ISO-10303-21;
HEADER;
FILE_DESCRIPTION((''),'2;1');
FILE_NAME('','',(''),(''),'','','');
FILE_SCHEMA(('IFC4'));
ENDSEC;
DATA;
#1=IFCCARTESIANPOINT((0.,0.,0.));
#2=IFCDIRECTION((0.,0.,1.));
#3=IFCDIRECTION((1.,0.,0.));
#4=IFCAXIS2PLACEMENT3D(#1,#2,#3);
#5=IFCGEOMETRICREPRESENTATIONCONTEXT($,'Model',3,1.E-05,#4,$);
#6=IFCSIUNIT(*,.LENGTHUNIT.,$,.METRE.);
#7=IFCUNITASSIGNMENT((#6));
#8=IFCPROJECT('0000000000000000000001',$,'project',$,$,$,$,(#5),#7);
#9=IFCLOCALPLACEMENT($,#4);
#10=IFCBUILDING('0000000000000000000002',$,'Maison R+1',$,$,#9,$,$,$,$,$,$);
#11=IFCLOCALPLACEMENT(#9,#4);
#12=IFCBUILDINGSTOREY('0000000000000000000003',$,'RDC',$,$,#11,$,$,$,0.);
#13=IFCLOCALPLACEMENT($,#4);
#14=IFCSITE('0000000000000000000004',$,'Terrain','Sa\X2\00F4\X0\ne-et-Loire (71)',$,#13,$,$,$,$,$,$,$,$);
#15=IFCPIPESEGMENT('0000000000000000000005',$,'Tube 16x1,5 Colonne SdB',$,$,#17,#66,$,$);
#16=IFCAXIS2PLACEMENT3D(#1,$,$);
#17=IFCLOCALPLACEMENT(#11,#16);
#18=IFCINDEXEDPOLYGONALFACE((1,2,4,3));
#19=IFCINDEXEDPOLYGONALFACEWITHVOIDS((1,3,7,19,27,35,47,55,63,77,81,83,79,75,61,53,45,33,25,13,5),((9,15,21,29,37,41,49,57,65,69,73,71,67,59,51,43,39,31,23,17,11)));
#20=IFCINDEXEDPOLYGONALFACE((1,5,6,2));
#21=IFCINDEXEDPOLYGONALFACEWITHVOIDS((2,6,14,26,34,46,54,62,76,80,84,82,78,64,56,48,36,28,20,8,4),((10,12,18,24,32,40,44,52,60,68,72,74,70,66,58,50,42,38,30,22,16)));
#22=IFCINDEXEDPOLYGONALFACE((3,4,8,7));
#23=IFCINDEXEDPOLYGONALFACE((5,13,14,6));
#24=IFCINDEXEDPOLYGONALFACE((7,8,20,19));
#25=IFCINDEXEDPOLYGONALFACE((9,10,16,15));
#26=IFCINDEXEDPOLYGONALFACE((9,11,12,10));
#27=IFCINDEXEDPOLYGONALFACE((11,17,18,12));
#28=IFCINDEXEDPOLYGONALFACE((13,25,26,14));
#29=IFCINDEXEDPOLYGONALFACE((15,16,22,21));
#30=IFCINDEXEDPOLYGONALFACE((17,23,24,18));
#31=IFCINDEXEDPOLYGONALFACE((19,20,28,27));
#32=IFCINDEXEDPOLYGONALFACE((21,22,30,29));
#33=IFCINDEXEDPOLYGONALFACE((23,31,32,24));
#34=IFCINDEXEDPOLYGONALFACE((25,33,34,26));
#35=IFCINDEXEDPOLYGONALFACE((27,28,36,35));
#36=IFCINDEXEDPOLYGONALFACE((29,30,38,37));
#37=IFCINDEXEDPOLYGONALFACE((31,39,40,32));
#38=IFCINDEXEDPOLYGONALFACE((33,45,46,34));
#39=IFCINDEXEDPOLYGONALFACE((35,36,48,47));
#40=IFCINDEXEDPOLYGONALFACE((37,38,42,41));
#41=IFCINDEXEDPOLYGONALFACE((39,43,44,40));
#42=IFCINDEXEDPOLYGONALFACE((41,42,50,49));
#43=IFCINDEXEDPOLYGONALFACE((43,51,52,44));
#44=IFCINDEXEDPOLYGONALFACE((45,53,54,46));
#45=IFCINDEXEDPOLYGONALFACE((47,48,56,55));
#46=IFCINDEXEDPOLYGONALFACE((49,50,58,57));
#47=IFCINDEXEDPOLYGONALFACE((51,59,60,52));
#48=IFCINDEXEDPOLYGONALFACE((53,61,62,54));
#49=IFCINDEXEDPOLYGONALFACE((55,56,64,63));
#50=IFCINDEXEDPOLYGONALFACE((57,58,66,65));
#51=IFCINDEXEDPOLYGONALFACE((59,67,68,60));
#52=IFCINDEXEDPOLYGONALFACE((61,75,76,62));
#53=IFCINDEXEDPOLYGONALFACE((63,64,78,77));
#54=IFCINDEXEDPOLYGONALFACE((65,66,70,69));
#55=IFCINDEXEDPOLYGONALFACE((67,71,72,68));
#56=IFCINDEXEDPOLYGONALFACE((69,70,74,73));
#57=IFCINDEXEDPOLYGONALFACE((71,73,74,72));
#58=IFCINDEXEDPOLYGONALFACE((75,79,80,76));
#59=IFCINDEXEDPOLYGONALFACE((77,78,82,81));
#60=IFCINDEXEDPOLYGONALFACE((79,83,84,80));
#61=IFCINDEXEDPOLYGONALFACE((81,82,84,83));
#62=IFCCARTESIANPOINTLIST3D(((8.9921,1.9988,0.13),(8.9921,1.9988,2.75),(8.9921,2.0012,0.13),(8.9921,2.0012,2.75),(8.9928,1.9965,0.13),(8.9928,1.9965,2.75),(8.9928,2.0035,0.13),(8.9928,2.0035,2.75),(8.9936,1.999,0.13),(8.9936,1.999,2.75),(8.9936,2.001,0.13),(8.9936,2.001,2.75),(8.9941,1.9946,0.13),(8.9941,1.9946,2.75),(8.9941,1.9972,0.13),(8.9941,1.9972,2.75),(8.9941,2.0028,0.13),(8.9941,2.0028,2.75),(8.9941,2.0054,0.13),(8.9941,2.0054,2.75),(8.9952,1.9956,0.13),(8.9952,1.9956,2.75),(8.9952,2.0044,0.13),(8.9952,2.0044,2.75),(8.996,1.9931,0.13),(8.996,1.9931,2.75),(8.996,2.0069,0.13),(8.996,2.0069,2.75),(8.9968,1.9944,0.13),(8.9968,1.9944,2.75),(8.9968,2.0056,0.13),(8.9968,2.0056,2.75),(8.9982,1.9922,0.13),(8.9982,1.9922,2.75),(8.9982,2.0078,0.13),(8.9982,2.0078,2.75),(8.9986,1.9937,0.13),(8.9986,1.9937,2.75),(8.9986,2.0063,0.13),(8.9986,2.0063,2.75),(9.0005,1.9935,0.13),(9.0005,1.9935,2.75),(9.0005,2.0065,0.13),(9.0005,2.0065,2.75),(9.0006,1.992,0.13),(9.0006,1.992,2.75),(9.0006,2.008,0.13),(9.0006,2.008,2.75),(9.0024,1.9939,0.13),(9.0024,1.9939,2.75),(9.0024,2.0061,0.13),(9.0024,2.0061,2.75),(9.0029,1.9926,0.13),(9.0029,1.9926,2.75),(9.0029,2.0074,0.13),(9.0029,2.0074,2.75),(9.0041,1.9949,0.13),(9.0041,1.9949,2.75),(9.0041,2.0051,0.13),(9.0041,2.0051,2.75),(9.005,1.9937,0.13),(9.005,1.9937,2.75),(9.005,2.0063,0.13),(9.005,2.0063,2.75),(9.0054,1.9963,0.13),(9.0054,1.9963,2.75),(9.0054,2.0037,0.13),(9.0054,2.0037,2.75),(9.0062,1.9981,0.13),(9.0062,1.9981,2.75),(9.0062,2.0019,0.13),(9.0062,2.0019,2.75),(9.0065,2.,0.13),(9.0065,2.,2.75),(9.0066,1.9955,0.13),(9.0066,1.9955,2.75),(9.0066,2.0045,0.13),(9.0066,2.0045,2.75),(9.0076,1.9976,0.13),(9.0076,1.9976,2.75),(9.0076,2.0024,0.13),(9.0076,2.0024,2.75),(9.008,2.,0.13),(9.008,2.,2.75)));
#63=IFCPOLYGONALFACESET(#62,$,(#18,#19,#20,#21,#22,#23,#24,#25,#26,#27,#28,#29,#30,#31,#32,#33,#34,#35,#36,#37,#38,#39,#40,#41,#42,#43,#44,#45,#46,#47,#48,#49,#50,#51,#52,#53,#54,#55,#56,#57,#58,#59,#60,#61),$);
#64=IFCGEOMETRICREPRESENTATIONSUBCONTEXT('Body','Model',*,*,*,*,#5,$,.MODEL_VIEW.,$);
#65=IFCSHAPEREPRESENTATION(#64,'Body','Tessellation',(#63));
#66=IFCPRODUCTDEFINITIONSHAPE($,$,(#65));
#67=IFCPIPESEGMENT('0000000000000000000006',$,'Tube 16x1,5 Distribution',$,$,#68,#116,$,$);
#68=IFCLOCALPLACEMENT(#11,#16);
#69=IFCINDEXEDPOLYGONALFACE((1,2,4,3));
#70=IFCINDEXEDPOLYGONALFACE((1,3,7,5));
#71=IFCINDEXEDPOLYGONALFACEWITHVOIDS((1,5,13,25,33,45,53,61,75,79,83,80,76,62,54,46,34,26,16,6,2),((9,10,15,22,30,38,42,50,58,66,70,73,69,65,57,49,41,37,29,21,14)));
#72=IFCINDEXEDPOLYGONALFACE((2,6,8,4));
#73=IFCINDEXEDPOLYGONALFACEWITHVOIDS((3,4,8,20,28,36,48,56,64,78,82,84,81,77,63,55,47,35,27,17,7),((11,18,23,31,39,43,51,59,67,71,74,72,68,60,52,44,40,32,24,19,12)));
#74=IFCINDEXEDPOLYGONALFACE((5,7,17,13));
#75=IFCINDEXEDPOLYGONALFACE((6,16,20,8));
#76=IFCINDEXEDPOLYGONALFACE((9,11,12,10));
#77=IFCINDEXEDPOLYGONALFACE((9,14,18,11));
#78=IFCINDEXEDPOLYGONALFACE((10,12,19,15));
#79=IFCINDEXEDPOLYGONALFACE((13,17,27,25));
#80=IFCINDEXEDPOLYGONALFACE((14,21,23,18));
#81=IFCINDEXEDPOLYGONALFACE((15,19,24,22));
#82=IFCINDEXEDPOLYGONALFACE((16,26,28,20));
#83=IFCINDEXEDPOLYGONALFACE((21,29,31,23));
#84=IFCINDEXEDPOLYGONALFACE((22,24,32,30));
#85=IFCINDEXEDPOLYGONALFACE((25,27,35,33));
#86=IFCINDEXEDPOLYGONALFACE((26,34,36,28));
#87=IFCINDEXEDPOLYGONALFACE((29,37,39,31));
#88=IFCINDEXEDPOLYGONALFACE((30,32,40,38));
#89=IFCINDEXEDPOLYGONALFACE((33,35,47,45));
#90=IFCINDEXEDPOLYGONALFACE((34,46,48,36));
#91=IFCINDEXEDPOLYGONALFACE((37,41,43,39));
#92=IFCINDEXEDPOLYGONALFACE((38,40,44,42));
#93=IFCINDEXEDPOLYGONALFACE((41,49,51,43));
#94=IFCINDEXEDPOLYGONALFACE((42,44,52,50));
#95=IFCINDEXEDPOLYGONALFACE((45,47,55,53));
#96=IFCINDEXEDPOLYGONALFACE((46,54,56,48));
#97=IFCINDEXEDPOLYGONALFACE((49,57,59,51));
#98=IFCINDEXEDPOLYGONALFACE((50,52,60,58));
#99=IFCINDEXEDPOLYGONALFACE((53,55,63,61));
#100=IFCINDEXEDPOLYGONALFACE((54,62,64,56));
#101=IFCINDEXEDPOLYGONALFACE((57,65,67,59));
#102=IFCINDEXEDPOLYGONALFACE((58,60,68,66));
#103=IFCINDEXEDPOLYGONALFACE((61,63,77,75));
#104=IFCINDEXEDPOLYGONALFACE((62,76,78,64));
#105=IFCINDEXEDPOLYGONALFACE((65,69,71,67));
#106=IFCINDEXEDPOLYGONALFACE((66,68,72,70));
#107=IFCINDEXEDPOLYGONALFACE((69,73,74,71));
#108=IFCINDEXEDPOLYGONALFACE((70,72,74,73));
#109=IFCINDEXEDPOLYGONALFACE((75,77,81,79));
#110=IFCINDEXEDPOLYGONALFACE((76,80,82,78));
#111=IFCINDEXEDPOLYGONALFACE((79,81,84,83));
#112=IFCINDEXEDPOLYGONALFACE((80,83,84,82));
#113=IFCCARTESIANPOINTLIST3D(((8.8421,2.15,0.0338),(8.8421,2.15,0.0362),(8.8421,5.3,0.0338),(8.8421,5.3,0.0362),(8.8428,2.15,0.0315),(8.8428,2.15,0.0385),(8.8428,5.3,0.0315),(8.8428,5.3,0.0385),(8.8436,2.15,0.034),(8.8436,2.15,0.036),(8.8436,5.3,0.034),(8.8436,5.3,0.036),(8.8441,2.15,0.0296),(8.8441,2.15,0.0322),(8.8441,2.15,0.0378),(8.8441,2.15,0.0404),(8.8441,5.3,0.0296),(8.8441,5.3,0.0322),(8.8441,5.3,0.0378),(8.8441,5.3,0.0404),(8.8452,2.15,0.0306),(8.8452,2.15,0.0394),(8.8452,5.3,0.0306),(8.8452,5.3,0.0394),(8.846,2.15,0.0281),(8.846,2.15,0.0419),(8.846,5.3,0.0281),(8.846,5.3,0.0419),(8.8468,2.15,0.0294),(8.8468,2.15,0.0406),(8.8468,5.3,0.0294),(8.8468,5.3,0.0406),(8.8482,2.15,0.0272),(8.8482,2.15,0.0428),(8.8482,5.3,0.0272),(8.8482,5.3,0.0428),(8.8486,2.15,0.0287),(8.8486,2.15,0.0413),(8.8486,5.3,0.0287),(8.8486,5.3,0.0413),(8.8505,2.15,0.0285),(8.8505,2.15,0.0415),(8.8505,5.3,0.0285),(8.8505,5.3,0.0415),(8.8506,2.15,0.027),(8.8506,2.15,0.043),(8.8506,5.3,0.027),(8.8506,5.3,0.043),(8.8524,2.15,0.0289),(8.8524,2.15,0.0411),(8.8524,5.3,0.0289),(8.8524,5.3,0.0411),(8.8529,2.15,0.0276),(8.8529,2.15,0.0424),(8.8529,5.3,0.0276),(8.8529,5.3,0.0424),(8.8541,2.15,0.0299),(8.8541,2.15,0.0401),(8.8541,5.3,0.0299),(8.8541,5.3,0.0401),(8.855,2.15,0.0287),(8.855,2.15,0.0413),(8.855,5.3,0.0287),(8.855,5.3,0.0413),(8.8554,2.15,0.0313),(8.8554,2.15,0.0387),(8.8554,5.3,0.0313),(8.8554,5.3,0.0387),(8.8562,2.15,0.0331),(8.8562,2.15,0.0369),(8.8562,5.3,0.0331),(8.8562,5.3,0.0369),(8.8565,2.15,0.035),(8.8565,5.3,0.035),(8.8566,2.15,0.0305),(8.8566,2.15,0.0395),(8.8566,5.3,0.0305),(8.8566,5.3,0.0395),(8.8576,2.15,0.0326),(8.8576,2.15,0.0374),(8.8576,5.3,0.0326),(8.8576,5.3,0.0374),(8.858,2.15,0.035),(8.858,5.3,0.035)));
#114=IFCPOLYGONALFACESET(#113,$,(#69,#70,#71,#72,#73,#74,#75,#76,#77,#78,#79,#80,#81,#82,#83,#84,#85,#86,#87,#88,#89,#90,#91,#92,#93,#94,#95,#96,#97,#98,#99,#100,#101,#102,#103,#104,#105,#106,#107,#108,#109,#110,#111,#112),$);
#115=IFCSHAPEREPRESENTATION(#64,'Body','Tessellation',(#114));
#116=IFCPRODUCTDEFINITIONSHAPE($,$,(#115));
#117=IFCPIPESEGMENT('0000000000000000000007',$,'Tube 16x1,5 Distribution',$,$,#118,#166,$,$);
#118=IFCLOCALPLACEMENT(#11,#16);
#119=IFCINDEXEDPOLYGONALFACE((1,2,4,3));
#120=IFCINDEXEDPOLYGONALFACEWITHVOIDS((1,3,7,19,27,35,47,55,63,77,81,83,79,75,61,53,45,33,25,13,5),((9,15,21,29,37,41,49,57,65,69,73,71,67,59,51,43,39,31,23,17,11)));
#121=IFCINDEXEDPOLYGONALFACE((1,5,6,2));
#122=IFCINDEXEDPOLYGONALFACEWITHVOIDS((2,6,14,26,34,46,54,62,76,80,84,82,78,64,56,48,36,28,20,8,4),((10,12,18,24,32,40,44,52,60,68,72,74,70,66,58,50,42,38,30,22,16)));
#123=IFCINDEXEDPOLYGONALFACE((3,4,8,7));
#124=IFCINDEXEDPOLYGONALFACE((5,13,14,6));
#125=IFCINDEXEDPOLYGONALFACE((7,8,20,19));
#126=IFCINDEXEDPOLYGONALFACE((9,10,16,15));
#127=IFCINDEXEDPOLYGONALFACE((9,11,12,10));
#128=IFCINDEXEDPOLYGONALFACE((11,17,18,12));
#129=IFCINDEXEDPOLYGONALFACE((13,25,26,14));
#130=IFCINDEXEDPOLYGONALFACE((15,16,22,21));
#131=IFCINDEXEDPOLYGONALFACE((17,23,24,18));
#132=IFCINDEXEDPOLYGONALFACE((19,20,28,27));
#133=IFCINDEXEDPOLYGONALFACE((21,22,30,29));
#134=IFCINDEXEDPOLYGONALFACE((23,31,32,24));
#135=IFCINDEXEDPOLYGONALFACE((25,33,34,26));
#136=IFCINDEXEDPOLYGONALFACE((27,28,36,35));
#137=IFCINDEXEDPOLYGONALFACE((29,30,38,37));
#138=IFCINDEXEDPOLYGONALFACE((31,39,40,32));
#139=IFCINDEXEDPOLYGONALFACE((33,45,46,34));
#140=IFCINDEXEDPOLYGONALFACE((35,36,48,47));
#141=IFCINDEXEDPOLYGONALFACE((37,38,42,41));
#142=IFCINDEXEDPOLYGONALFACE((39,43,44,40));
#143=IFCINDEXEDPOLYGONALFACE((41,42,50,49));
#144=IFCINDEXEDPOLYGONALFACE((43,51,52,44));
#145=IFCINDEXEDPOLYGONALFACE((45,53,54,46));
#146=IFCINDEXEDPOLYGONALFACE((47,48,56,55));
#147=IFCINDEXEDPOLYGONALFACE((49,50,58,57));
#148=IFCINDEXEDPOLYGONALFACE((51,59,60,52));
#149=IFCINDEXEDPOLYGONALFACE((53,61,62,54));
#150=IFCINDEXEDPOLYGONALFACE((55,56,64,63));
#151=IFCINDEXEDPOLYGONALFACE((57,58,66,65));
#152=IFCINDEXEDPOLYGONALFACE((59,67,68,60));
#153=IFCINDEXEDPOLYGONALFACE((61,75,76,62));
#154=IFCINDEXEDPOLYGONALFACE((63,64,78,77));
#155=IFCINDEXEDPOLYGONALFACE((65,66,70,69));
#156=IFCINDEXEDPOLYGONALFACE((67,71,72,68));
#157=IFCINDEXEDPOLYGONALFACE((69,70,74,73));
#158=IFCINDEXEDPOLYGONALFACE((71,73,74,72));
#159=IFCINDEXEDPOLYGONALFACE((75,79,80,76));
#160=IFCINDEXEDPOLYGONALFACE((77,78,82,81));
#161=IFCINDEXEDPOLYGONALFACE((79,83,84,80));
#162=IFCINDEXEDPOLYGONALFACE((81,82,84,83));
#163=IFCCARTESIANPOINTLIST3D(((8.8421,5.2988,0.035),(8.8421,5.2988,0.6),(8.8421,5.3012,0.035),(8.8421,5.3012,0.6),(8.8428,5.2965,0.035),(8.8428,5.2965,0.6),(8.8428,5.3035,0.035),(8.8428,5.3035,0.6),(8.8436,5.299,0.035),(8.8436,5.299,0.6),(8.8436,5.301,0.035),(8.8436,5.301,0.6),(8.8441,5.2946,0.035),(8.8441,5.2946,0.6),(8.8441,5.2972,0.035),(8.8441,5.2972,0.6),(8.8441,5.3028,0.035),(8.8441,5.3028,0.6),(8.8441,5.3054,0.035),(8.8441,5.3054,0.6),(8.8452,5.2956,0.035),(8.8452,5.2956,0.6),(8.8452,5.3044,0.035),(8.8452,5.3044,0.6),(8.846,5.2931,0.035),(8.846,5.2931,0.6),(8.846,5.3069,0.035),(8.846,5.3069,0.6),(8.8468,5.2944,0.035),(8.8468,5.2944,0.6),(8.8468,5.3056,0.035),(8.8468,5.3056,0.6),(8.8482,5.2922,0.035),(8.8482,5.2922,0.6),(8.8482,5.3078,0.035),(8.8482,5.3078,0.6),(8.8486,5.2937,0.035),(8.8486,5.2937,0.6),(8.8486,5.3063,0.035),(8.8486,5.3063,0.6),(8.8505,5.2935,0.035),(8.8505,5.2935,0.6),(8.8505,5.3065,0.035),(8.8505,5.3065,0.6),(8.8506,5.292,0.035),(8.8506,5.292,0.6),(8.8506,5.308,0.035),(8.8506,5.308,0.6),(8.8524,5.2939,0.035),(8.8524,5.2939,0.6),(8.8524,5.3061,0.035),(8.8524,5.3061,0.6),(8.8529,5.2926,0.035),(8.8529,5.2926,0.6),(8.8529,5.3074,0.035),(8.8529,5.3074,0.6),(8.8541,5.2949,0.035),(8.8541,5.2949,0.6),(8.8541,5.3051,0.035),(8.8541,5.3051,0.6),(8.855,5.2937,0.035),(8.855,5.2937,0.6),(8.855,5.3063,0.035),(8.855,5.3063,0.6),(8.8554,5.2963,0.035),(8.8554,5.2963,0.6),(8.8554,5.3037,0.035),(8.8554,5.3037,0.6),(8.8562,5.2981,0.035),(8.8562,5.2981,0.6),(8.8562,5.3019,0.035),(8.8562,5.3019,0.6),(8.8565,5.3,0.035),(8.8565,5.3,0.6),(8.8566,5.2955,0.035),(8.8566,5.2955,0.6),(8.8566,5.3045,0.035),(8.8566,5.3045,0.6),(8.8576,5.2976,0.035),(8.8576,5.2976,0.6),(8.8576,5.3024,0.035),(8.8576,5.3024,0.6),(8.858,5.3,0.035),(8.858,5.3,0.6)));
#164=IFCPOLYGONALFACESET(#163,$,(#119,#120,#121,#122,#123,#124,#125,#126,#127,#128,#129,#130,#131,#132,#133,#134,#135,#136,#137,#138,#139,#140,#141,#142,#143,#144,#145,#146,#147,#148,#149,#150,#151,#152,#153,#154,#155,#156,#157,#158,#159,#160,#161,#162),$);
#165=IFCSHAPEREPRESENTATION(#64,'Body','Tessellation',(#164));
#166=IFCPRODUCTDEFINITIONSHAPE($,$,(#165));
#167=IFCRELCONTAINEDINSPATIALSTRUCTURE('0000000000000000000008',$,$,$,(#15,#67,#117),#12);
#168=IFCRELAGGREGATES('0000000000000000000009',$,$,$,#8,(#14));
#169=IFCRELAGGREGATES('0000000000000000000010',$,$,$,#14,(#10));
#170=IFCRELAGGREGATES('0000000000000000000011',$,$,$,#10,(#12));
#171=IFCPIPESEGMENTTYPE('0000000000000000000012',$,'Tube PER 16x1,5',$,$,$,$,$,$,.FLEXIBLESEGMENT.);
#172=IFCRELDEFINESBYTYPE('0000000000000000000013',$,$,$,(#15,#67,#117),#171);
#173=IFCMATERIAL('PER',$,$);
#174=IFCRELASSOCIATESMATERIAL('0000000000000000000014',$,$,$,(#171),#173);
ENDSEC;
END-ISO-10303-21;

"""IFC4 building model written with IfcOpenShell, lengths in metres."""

from ifc_helpers import new_model, si_unit, frame, origin_with_axes, place, context, subcontext, project, spatial, hollow_circle, extrude, material, type_object, element, save


model = new_model("IFC4")

# Units and contexts
model_context = context("Model", 3, precision=1e-05, world=origin_with_axes())
body_context = subcontext(model_context, "Body", "Model", "MODEL_VIEW")
ifc_project = project(units=[si_unit("LENGTHUNIT", "METRE")], contexts=[model_context])

# Site, building, storey
site_placement = place(None, origin_with_axes())
site = spatial("IfcSite", under=ifc_project, at=site_placement, Name="Terrain", Description="Saône-et-Loire (71)")
building_placement = place(None, origin_with_axes())
building = spatial("IfcBuilding", under=site, at=building_placement, Name="Maison R+1")
storey_placement = place(building_placement, origin_with_axes())
storey = spatial("IfcBuildingStorey", under=building, at=storey_placement, Name="RDC", Elevation=0.0)

# Pipe segments
ifc_material_1 = material(Name="PER")
pipe_segment_type_1 = type_object("IfcPipeSegmentType", Name="Tube PER 16x1,5", PredefinedType="FLEXIBLESEGMENT", material=ifc_material_1)
pipe_segment_1_placement = place(storey_placement, frame((9.0, 2.0, 0.13), z_axis=(0.0, 0.0, 1.0), x_axis=(1.0, 0.0, 0.0)))
element("IfcPipeSegment", 1, at=pipe_segment_1_placement, inside=storey, type_object=pipe_segment_type_1, Name="Tube 16x1,5 Colonne SdB", context=body_context, shape_type="SweptSolid", body=[
    extrude(hollow_circle(Radius=0.008, WallThickness=0.0015), origin_with_axes(), (0.0, 0.0, 1.0), 2.62),
])
pipe_segment_2_placement = place(storey_placement, frame((8.85, 2.15, 0.035), z_axis=(0.0, 1.0, 0.0), x_axis=(1.0, 0.0, 0.0)))
element("IfcPipeSegment", 2, at=pipe_segment_2_placement, inside=storey, type_object=pipe_segment_type_1, Name="Tube 16x1,5 Distribution", context=body_context, shape_type="SweptSolid", body=[
    extrude(hollow_circle(Radius=0.008, WallThickness=0.0015), origin_with_axes(), (0.0, 0.0, 1.0), 3.15),
])
pipe_segment_3_placement = place(storey_placement, frame((8.85, 5.3, 0.035), z_axis=(0.0, 0.0, 1.0), x_axis=(1.0, 0.0, 0.0)))
element("IfcPipeSegment", 3, at=pipe_segment_3_placement, inside=storey, type_object=pipe_segment_type_1, Name="Tube 16x1,5 Distribution", context=body_context, shape_type="SweptSolid", body=[
    extrude(hollow_circle(Radius=0.008, WallThickness=0.0015), origin_with_axes(), (0.0, 0.0, 1.0), 0.565),
])

save(model, "model.ifc")
